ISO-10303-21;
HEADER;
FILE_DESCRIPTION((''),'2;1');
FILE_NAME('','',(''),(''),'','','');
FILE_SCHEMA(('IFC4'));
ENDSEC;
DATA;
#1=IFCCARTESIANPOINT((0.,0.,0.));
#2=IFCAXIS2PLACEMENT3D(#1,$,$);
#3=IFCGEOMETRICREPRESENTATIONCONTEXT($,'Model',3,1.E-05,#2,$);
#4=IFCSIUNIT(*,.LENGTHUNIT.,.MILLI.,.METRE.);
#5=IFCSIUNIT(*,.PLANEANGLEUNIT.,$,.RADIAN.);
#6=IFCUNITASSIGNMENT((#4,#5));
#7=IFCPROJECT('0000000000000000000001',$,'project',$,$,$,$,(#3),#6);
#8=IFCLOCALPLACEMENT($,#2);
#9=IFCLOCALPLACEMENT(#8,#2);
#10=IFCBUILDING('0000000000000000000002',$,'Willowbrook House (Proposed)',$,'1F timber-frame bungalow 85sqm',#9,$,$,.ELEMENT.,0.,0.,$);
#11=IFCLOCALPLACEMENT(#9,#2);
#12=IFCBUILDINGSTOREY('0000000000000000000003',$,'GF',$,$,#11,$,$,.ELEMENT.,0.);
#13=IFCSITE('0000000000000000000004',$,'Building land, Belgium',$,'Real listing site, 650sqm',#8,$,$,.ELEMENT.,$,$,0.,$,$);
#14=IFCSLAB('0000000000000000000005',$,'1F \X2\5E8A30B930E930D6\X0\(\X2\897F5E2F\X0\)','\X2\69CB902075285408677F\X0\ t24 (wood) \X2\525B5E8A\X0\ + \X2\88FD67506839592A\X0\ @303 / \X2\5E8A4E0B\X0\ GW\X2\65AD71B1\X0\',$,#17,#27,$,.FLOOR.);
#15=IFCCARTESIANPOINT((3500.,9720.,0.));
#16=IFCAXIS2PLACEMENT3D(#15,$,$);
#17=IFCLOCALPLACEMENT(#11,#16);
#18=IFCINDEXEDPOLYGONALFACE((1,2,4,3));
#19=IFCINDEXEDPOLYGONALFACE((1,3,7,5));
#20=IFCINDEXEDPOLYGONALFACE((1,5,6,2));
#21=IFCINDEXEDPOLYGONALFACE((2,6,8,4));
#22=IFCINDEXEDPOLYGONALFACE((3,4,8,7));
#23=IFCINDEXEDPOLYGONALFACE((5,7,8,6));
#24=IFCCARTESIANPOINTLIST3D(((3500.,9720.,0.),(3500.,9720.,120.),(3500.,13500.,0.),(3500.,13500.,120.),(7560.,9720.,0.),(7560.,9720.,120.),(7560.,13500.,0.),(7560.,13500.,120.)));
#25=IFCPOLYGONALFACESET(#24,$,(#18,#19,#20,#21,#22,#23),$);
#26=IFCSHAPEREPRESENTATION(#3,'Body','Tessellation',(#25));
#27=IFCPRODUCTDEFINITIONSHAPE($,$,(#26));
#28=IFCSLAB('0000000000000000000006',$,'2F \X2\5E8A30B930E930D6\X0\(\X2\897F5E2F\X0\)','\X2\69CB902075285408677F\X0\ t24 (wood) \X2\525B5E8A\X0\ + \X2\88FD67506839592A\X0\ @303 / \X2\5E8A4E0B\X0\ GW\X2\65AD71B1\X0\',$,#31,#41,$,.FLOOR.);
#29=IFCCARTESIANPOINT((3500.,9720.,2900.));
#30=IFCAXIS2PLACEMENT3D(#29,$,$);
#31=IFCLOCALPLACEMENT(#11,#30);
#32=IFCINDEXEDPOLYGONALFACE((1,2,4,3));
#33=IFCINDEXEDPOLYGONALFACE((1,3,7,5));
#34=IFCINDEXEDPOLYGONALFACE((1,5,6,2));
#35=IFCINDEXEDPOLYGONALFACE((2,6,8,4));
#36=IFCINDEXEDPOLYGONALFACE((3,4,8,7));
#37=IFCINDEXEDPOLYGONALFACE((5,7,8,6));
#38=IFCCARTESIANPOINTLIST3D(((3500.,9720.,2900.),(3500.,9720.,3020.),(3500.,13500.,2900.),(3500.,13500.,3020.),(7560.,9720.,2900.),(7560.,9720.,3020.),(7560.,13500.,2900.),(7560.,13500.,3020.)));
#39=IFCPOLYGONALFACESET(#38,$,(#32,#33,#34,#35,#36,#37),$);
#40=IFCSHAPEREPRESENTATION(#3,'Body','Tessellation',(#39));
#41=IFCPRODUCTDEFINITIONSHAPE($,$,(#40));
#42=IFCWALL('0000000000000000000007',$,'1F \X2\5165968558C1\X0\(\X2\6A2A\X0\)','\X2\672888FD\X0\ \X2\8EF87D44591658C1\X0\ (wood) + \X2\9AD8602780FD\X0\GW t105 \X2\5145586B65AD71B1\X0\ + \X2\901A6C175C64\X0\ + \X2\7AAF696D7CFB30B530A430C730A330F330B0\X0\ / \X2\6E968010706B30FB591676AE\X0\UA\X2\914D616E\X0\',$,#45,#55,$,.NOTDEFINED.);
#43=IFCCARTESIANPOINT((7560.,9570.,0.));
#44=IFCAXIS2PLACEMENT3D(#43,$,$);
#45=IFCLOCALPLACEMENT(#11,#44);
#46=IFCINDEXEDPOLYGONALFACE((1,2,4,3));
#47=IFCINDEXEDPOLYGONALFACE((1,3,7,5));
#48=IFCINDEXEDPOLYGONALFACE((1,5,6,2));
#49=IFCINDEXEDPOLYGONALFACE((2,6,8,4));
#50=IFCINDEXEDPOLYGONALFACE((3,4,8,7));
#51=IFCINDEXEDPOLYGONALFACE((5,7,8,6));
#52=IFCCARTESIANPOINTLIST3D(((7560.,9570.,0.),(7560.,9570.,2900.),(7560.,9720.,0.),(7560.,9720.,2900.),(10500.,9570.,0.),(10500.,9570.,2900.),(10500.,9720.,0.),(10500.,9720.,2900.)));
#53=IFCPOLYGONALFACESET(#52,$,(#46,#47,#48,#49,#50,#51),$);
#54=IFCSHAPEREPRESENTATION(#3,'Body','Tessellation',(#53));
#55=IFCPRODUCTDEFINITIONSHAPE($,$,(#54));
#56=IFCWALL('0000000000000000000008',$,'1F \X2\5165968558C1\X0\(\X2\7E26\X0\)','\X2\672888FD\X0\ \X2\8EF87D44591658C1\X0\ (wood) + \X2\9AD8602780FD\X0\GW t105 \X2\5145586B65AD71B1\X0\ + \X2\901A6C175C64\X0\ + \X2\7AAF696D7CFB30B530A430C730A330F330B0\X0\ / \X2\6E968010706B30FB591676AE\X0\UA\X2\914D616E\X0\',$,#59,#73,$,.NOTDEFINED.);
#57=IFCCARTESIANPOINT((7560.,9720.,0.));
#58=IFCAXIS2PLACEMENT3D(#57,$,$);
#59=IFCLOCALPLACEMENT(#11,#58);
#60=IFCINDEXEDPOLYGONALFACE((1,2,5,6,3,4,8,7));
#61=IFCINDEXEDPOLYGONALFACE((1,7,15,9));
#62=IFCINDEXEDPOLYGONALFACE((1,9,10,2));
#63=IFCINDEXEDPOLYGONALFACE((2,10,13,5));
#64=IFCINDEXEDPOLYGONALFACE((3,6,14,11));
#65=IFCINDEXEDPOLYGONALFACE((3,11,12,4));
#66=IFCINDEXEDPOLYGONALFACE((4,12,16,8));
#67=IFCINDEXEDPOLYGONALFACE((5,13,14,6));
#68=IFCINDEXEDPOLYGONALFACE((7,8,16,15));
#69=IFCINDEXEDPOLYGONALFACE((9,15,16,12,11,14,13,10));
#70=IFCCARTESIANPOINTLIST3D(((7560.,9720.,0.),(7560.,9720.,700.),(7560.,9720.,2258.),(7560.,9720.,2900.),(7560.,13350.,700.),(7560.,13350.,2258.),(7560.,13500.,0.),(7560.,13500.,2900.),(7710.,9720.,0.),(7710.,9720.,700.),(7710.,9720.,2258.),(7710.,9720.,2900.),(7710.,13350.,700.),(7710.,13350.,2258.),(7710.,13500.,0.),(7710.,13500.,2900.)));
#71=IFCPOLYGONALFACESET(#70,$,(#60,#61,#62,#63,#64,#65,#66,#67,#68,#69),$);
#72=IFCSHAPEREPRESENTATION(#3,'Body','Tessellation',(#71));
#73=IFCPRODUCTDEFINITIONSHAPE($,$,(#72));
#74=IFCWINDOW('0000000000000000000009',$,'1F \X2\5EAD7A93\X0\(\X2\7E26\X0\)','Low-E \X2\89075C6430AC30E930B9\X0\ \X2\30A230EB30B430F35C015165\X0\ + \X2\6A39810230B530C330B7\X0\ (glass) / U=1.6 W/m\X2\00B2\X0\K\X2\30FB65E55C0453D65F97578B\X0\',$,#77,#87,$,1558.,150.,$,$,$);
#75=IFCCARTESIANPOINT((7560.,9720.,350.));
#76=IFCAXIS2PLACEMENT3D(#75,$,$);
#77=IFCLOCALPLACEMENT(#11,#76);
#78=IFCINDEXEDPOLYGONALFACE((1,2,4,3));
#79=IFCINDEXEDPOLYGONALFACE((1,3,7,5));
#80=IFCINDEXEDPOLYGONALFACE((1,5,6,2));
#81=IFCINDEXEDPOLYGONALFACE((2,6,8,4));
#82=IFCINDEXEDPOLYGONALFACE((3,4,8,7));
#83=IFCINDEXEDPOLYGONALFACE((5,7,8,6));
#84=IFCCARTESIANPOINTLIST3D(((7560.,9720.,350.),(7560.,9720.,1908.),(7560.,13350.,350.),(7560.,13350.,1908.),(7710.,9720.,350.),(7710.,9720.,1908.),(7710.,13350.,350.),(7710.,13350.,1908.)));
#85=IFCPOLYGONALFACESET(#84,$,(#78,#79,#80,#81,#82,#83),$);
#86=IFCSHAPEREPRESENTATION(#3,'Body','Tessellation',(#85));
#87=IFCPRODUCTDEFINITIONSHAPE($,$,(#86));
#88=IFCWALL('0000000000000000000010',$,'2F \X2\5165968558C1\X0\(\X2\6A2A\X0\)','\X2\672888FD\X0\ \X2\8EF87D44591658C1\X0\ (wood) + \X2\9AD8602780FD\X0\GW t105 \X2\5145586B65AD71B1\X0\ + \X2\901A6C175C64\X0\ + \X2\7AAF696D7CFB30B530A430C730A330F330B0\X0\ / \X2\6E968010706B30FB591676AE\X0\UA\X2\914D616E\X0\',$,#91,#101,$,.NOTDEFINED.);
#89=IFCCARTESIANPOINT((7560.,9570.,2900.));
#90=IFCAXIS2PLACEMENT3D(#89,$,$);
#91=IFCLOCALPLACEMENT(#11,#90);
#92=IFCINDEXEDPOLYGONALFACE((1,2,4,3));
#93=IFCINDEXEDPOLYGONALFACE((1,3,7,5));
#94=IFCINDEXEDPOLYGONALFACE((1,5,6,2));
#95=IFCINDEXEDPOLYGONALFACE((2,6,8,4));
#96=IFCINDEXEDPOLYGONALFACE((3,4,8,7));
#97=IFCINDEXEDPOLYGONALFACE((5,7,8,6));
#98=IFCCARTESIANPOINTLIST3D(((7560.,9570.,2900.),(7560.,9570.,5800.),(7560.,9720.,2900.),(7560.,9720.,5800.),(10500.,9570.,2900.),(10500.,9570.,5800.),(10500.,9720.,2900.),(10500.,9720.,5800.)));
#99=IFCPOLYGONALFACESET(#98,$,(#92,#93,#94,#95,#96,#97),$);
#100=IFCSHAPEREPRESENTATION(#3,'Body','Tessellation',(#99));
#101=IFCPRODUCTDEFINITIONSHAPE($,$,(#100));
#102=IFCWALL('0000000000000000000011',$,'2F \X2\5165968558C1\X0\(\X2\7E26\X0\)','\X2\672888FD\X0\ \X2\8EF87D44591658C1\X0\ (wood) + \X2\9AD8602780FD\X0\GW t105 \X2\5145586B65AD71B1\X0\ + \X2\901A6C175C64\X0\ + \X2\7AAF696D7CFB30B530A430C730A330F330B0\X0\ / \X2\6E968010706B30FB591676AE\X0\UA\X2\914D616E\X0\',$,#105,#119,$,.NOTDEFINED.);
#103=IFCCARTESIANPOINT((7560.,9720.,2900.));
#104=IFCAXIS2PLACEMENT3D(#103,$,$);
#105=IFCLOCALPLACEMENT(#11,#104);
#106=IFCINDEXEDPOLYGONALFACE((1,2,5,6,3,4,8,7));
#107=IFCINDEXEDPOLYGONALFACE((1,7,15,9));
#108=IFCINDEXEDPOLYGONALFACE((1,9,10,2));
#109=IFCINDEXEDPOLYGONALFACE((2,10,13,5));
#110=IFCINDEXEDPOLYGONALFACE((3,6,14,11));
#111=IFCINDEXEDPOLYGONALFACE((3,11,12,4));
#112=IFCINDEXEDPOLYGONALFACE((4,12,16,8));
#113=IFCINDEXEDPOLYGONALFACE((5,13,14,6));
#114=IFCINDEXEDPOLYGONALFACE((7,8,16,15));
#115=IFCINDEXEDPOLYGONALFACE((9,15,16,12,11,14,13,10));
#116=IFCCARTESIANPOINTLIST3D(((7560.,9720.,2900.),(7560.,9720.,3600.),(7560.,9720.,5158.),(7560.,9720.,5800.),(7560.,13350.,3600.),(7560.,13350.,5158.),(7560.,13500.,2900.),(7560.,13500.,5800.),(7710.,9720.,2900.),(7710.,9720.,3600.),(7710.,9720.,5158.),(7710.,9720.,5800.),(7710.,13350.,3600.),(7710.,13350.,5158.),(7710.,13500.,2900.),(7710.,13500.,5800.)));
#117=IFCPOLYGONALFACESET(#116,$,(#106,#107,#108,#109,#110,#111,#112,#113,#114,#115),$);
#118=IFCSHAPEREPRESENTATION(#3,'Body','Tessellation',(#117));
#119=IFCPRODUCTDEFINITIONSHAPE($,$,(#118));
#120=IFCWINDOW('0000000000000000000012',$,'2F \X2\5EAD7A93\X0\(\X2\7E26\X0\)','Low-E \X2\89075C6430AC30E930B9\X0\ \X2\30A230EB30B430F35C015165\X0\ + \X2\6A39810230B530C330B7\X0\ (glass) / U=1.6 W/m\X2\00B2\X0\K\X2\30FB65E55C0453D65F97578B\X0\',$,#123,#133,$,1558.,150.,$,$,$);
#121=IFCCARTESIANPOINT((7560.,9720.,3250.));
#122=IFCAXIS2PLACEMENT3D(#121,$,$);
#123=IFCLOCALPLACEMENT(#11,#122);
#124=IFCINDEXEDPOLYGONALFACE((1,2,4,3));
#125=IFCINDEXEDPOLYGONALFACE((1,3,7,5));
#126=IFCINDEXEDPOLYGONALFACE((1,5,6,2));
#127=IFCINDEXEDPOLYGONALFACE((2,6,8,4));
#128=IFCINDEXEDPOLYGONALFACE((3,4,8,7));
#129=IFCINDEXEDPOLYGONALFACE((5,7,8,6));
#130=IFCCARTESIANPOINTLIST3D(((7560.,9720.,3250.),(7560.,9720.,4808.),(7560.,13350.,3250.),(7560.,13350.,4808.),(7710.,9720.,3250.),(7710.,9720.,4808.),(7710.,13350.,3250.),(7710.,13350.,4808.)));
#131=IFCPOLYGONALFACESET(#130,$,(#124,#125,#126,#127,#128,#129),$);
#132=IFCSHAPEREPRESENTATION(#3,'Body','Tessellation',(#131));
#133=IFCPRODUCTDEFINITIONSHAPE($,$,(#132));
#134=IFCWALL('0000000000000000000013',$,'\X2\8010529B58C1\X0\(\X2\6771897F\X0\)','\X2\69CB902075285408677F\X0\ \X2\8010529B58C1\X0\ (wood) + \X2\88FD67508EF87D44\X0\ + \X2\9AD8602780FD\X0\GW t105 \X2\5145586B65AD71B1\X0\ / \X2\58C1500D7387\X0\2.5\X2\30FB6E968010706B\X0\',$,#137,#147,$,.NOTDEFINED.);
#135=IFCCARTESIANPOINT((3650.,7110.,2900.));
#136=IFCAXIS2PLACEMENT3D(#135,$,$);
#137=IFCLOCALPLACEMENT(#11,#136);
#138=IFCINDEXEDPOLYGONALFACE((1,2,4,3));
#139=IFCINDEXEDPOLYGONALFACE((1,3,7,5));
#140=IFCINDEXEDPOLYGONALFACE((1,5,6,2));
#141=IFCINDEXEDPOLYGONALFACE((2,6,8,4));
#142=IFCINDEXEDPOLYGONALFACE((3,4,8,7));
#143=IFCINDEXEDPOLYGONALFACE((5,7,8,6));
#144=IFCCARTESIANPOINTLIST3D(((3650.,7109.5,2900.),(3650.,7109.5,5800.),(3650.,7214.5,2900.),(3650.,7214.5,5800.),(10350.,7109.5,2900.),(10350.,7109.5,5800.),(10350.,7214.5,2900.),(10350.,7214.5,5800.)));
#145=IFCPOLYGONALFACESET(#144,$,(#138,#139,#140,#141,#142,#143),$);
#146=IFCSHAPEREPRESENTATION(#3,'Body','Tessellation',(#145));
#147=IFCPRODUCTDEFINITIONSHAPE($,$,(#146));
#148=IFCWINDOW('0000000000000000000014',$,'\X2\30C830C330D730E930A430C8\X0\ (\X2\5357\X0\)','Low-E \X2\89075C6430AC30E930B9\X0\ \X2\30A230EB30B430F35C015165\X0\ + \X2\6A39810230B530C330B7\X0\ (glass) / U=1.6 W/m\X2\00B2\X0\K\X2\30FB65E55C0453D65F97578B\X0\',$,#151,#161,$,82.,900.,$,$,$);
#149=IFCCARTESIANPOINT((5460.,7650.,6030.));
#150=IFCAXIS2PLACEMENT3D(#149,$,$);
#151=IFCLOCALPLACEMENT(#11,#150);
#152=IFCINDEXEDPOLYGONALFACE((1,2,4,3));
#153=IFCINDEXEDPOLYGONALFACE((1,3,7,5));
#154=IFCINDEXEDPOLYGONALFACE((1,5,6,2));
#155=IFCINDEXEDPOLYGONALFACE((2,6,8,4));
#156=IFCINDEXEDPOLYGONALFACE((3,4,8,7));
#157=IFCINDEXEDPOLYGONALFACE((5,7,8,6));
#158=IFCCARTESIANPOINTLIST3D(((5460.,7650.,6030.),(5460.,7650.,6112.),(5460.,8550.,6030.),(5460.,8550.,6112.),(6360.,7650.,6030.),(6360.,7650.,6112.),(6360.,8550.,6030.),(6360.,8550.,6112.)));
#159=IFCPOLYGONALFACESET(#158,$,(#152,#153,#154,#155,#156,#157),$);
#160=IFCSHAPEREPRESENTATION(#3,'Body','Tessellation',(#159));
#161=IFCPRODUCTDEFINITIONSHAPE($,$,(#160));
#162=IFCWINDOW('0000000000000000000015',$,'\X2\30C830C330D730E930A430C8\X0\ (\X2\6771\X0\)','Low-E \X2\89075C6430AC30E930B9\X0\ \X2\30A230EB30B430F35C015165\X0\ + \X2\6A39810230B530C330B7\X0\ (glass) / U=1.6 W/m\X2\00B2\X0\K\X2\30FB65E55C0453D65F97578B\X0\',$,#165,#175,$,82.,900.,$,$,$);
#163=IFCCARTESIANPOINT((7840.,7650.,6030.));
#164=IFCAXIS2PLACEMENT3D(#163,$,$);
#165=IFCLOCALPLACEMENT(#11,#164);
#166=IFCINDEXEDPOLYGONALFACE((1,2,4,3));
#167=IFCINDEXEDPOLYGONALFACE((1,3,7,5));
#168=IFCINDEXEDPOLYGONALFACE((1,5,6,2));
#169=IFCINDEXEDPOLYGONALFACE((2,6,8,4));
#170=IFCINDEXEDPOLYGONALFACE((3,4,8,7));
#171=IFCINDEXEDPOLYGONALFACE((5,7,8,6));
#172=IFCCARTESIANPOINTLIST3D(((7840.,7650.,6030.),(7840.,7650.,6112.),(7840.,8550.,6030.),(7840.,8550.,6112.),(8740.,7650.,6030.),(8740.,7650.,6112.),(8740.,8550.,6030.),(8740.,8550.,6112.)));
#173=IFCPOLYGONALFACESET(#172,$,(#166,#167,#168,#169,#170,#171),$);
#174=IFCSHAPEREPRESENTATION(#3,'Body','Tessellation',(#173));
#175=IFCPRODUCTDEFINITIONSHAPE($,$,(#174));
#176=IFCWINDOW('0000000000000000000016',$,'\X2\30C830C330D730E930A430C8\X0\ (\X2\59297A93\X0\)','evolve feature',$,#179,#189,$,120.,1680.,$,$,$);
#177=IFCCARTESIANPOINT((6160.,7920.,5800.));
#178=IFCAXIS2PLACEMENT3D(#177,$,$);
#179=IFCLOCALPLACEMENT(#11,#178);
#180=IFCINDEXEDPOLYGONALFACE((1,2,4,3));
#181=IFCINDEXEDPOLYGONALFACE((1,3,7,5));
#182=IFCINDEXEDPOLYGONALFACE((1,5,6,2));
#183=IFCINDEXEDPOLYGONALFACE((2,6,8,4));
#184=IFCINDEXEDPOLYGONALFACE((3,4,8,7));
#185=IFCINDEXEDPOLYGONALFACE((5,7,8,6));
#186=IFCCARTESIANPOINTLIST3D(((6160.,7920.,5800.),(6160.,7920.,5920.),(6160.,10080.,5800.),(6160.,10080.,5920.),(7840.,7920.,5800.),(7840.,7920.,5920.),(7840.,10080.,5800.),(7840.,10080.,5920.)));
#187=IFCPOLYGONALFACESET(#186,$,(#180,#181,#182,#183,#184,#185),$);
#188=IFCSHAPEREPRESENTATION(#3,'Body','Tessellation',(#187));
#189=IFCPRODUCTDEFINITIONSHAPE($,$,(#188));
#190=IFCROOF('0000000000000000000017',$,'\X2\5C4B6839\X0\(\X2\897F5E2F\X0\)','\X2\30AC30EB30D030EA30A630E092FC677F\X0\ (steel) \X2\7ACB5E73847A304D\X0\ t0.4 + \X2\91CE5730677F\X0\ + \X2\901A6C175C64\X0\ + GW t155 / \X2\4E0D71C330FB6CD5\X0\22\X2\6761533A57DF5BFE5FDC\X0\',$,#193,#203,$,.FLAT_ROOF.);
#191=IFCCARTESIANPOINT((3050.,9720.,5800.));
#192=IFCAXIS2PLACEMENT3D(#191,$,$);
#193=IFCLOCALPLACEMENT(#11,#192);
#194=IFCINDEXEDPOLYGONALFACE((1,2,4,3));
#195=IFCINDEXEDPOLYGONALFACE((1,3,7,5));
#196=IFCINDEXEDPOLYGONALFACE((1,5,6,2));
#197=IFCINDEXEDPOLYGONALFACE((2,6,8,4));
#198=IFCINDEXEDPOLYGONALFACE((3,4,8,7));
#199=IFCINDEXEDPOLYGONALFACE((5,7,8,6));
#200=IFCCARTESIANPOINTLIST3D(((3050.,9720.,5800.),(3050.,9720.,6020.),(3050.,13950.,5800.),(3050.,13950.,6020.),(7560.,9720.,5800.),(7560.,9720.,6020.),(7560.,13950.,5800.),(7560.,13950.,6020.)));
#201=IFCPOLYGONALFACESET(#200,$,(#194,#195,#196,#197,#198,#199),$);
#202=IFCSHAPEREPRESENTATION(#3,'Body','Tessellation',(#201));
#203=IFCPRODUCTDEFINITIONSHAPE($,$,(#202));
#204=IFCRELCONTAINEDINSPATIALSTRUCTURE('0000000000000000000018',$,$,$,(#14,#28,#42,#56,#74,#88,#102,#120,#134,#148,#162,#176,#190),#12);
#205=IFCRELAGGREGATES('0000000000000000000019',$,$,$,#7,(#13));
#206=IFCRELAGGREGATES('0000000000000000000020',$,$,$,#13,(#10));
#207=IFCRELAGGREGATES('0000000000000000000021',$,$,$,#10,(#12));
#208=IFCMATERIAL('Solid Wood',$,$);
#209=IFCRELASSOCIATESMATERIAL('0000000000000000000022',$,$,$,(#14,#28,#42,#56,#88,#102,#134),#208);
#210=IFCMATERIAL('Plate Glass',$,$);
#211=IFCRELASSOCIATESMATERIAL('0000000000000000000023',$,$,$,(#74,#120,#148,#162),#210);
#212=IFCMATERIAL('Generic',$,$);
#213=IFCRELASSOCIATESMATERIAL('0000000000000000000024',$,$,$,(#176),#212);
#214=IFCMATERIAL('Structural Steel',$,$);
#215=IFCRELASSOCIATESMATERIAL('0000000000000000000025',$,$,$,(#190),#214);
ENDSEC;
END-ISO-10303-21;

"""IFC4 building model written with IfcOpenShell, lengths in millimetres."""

from ifc_helpers import new_model, si_unit, frame, frame_2d, origin, place, context, project, spatial, rectangle, extrude, material, element, fill, save


model = new_model("IFC4")

# Units and contexts
model_context = context("Model", 3, precision=1e-05, world=origin())
ifc_project = project(units=[si_unit("LENGTHUNIT", "METRE", prefix="MILLI"), si_unit("PLANEANGLEUNIT", "RADIAN")], contexts=[model_context])

# Site, building, storey
site_placement = place(None, origin())
site = spatial("IfcSite", under=ifc_project, at=site_placement, Name="Building land, Belgium", ObjectType="Real listing site, 650sqm", CompositionType="ELEMENT", RefElevation=0.0)
building_placement = place(site_placement, origin())
building = spatial("IfcBuilding", under=site, at=building_placement, Name="Willowbrook House (Proposed)", ObjectType="1F timber-frame bungalow 85sqm", CompositionType="ELEMENT", ElevationOfRefHeight=0.0, ElevationOfTerrain=0.0)
storey_placement = place(building_placement, origin())
storey = spatial("IfcBuildingStorey", under=building, at=storey_placement, Name="GF", CompositionType="ELEMENT", Elevation=0.0)

# Slabs
ifc_material_1 = material(Name="Solid Wood")
slab_1_placement = place(storey_placement, frame((3500.0, 9720.0, 0.0)))
element("IfcSlab", 1, at=slab_1_placement, inside=storey, material=ifc_material_1, Name="1F 床スラブ(西帯)", Description="構造用合板 t24 (wood) 剛床 + 製材根太 @303 / 床下 GW断熱", PredefinedType="FLOOR", context=model_context, shape_type="SweptSolid", body=[
    extrude(rectangle(XDim=4060.0, YDim=3780.0, at=frame_2d((2030.0, 1890.0))), frame((3500.0, 9720.0, 0.0)), (0.0, 0.0, 1.0), 120.0),
])
slab_2_placement = place(storey_placement, frame((3500.0, 9720.0, 2900.0)))
element("IfcSlab", 2, at=slab_2_placement, inside=storey, material=ifc_material_1, Name="2F 床スラブ(西帯)", Description="構造用合板 t24 (wood) 剛床 + 製材根太 @303 / 床下 GW断熱", PredefinedType="FLOOR", context=model_context, shape_type="SweptSolid", body=[
    extrude(rectangle(XDim=4060.0, YDim=3780.0, at=frame_2d((2030.0, 1890.0))), frame((3500.0, 9720.0, 2900.0)), (0.0, 0.0, 1.0), 120.0),
])

# Wall
wall_1_placement = place(storey_placement, frame((7560.0, 9570.0, 0.0)))
element("IfcWall", 3, at=wall_1_placement, inside=storey, material=ifc_material_1, Name="1F 入隅壁(横)", Description="木製 軸組外壁 (wood) + 高性能GW t105 充填断熱 + 通気層 + 窯業系サイディング / 準耐火・外皮UA配慮", PredefinedType="NOTDEFINED", context=model_context, shape_type="SweptSolid", body=[
    extrude(rectangle(XDim=2940.0, YDim=150.0, at=frame_2d((1470.0, 75.0))), frame((7560.0, 9570.0, 0.0)), (0.0, 0.0, 1.0), 2900.0),
])

# Wall, opening, window
wall_2_placement = place(storey_placement, frame((7560.0, 9720.0, 0.0)))
wall_2 = element("IfcWall", 4, at=wall_2_placement, inside=storey, material=ifc_material_1, Name="1F 入隅壁(縦)", Description="木製 軸組外壁 (wood) + 高性能GW t105 充填断熱 + 通気層 + 窯業系サイディング / 準耐火・外皮UA配慮", PredefinedType="NOTDEFINED", context=model_context, shape_type="SweptSolid", body=[
    extrude(rectangle(XDim=150.0, YDim=3780.0, at=frame_2d((75.0, 1890.0))), frame((7560.0, 9720.0, 0.0)), (0.0, 0.0, 1.0), 2900.0),
])
opening_1_placement = place(storey_placement, frame((7560.0, 9720.0, 350.0)))
opening_1 = element("IfcOpeningElement", 5, at=opening_1_placement, cuts=wall_2, PredefinedType="NOTDEFINED", context=model_context, shape_type="SweptSolid", body=[
    extrude(rectangle(XDim=150.0, YDim=3630.0, at=frame_2d((75.0, 1815.0))), frame((7560.0, 9720.0, 350.0)), (0.0, 0.0, 1.0), 1558.0),
])
ifc_material_2 = material(Name="Plate Glass")
window_1_placement = place(storey_placement, frame((7560.0, 9720.0, 350.0)))
window_1 = element("IfcWindow", 6, at=window_1_placement, inside=storey, material=ifc_material_2, Name="1F 庭窓(縦)", Description="Low-E 複層ガラス アルゴン封入 + 樹脂サッシ (glass) / U=1.6 W/m²K・日射取得型", OverallHeight=1558.0, OverallWidth=150.0, context=model_context, shape_type="SweptSolid", body=[
    extrude(rectangle(XDim=150.0, YDim=3630.0, at=frame_2d((75.0, 1815.0))), frame((7560.0, 9720.0, 350.0)), (0.0, 0.0, 1.0), 1558.0),
])
fill(opening_1, window_1)

# Wall
wall_3_placement = place(storey_placement, frame((7560.0, 9570.0, 2900.0)))
element("IfcWall", 7, at=wall_3_placement, inside=storey, material=ifc_material_1, Name="2F 入隅壁(横)", Description="木製 軸組外壁 (wood) + 高性能GW t105 充填断熱 + 通気層 + 窯業系サイディング / 準耐火・外皮UA配慮", PredefinedType="NOTDEFINED", context=model_context, shape_type="SweptSolid", body=[
    extrude(rectangle(XDim=2940.0, YDim=150.0, at=frame_2d((1470.0, 75.0))), frame((7560.0, 9570.0, 2900.0)), (0.0, 0.0, 1.0), 2900.0),
])

# Wall, opening, window
wall_4_placement = place(storey_placement, frame((7560.0, 9720.0, 2900.0)))
wall_4 = element("IfcWall", 8, at=wall_4_placement, inside=storey, material=ifc_material_1, Name="2F 入隅壁(縦)", Description="木製 軸組外壁 (wood) + 高性能GW t105 充填断熱 + 通気層 + 窯業系サイディング / 準耐火・外皮UA配慮", PredefinedType="NOTDEFINED", context=model_context, shape_type="SweptSolid", body=[
    extrude(rectangle(XDim=150.0, YDim=3780.0, at=frame_2d((75.0, 1890.0))), frame((7560.0, 9720.0, 2900.0)), (0.0, 0.0, 1.0), 2900.0),
])
opening_2_placement = place(storey_placement, frame((7560.0, 9720.0, 3250.0)))
opening_2 = element("IfcOpeningElement", 9, at=opening_2_placement, cuts=wall_4, PredefinedType="NOTDEFINED", context=model_context, shape_type="SweptSolid", body=[
    extrude(rectangle(XDim=150.0, YDim=3630.0, at=frame_2d((75.0, 1815.0))), frame((7560.0, 9720.0, 3250.0)), (0.0, 0.0, 1.0), 1558.0),
])
window_2_placement = place(storey_placement, frame((7560.0, 9720.0, 3250.0)))
window_2 = element("IfcWindow", 10, at=window_2_placement, inside=storey, material=ifc_material_2, Name="2F 庭窓(縦)", Description="Low-E 複層ガラス アルゴン封入 + 樹脂サッシ (glass) / U=1.6 W/m²K・日射取得型", OverallHeight=1558.0, OverallWidth=150.0, context=model_context, shape_type="SweptSolid", body=[
    extrude(rectangle(XDim=150.0, YDim=3630.0, at=frame_2d((75.0, 1815.0))), frame((7560.0, 9720.0, 3250.0)), (0.0, 0.0, 1.0), 1558.0),
])
fill(opening_2, window_2)

# Wall
wall_5_placement = place(storey_placement, frame((3650.0, 7110.0, 2900.0)))
element("IfcWall", 11, at=wall_5_placement, inside=storey, material=ifc_material_1, Name="耐力壁(東西)", Description="構造用合板 耐力壁 (wood) + 製材軸組 + 高性能GW t105 充填断熱 / 壁倍率2.5・準耐火", PredefinedType="NOTDEFINED", context=model_context, shape_type="SweptSolid", body=[
    extrude(rectangle(XDim=6700.0, YDim=105.0, at=frame_2d((3350.0, 52.0))), frame((3650.0, 7110.0, 2900.0)), (0.0, 0.0, 1.0), 2900.0),
])

# Windows
window_3_placement = place(storey_placement, frame((5460.0, 7650.0, 6030.0)))
element("IfcWindow", 12, at=window_3_placement, inside=storey, material=ifc_material_2, Name="トップライト (南)", Description="Low-E 複層ガラス アルゴン封入 + 樹脂サッシ (glass) / U=1.6 W/m²K・日射取得型", OverallHeight=82.0, OverallWidth=900.0, context=model_context, shape_type="SweptSolid", body=[
    extrude(rectangle(XDim=900.0, YDim=900.0, at=frame_2d((450.0, 450.0))), frame((5460.0, 7650.0, 6030.0)), (0.0, 0.0, 1.0), 82.0),
])
window_4_placement = place(storey_placement, frame((7840.0, 7650.0, 6030.0)))
element("IfcWindow", 13, at=window_4_placement, inside=storey, material=ifc_material_2, Name="トップライト (東)", Description="Low-E 複層ガラス アルゴン封入 + 樹脂サッシ (glass) / U=1.6 W/m²K・日射取得型", OverallHeight=82.0, OverallWidth=900.0, context=model_context, shape_type="SweptSolid", body=[
    extrude(rectangle(XDim=900.0, YDim=900.0, at=frame_2d((450.0, 450.0))), frame((7840.0, 7650.0, 6030.0)), (0.0, 0.0, 1.0), 82.0),
])
ifc_material_3 = material(Name="Generic")
window_5_placement = place(storey_placement, frame((6160.0, 7920.0, 5800.0)))
element("IfcWindow", 14, at=window_5_placement, inside=storey, material=ifc_material_3, Name="トップライト (天窓)", Description="evolve feature", OverallHeight=120.0, OverallWidth=1680.0, context=model_context, shape_type="SweptSolid", body=[
    extrude(rectangle(XDim=1680.0, YDim=2160.0, at=frame_2d((840.0, 1080.0))), frame((6160.0, 7920.0, 5800.0)), (0.0, 0.0, 1.0), 120.0),
])

# Roof
ifc_material_4 = material(Name="Structural Steel")
for number, where, name in (
    (15, (3050.0, 9720.0, 5800.0), "屋根(西帯)"),
):
    element("IfcRoof", number, at=place(storey_placement, frame(where)), inside=storey, material=ifc_material_4, Name=name, Description="ガルバリウム鋼板 (steel) 立平葺き t0.4 + 野地板 + 通気層 + GW t155 / 不燃・法22条区域対応", PredefinedType="FLAT_ROOF", context=model_context, shape_type="SweptSolid", body=[
        extrude(rectangle(XDim=4510.0, YDim=4230.0, at=frame_2d((2255.0, 2115.0))), frame((3050.0, 9720.0, 5800.0)), (0.0, 0.0, 1.0), 220.0),
    ])

save(model, "model.ifc")
